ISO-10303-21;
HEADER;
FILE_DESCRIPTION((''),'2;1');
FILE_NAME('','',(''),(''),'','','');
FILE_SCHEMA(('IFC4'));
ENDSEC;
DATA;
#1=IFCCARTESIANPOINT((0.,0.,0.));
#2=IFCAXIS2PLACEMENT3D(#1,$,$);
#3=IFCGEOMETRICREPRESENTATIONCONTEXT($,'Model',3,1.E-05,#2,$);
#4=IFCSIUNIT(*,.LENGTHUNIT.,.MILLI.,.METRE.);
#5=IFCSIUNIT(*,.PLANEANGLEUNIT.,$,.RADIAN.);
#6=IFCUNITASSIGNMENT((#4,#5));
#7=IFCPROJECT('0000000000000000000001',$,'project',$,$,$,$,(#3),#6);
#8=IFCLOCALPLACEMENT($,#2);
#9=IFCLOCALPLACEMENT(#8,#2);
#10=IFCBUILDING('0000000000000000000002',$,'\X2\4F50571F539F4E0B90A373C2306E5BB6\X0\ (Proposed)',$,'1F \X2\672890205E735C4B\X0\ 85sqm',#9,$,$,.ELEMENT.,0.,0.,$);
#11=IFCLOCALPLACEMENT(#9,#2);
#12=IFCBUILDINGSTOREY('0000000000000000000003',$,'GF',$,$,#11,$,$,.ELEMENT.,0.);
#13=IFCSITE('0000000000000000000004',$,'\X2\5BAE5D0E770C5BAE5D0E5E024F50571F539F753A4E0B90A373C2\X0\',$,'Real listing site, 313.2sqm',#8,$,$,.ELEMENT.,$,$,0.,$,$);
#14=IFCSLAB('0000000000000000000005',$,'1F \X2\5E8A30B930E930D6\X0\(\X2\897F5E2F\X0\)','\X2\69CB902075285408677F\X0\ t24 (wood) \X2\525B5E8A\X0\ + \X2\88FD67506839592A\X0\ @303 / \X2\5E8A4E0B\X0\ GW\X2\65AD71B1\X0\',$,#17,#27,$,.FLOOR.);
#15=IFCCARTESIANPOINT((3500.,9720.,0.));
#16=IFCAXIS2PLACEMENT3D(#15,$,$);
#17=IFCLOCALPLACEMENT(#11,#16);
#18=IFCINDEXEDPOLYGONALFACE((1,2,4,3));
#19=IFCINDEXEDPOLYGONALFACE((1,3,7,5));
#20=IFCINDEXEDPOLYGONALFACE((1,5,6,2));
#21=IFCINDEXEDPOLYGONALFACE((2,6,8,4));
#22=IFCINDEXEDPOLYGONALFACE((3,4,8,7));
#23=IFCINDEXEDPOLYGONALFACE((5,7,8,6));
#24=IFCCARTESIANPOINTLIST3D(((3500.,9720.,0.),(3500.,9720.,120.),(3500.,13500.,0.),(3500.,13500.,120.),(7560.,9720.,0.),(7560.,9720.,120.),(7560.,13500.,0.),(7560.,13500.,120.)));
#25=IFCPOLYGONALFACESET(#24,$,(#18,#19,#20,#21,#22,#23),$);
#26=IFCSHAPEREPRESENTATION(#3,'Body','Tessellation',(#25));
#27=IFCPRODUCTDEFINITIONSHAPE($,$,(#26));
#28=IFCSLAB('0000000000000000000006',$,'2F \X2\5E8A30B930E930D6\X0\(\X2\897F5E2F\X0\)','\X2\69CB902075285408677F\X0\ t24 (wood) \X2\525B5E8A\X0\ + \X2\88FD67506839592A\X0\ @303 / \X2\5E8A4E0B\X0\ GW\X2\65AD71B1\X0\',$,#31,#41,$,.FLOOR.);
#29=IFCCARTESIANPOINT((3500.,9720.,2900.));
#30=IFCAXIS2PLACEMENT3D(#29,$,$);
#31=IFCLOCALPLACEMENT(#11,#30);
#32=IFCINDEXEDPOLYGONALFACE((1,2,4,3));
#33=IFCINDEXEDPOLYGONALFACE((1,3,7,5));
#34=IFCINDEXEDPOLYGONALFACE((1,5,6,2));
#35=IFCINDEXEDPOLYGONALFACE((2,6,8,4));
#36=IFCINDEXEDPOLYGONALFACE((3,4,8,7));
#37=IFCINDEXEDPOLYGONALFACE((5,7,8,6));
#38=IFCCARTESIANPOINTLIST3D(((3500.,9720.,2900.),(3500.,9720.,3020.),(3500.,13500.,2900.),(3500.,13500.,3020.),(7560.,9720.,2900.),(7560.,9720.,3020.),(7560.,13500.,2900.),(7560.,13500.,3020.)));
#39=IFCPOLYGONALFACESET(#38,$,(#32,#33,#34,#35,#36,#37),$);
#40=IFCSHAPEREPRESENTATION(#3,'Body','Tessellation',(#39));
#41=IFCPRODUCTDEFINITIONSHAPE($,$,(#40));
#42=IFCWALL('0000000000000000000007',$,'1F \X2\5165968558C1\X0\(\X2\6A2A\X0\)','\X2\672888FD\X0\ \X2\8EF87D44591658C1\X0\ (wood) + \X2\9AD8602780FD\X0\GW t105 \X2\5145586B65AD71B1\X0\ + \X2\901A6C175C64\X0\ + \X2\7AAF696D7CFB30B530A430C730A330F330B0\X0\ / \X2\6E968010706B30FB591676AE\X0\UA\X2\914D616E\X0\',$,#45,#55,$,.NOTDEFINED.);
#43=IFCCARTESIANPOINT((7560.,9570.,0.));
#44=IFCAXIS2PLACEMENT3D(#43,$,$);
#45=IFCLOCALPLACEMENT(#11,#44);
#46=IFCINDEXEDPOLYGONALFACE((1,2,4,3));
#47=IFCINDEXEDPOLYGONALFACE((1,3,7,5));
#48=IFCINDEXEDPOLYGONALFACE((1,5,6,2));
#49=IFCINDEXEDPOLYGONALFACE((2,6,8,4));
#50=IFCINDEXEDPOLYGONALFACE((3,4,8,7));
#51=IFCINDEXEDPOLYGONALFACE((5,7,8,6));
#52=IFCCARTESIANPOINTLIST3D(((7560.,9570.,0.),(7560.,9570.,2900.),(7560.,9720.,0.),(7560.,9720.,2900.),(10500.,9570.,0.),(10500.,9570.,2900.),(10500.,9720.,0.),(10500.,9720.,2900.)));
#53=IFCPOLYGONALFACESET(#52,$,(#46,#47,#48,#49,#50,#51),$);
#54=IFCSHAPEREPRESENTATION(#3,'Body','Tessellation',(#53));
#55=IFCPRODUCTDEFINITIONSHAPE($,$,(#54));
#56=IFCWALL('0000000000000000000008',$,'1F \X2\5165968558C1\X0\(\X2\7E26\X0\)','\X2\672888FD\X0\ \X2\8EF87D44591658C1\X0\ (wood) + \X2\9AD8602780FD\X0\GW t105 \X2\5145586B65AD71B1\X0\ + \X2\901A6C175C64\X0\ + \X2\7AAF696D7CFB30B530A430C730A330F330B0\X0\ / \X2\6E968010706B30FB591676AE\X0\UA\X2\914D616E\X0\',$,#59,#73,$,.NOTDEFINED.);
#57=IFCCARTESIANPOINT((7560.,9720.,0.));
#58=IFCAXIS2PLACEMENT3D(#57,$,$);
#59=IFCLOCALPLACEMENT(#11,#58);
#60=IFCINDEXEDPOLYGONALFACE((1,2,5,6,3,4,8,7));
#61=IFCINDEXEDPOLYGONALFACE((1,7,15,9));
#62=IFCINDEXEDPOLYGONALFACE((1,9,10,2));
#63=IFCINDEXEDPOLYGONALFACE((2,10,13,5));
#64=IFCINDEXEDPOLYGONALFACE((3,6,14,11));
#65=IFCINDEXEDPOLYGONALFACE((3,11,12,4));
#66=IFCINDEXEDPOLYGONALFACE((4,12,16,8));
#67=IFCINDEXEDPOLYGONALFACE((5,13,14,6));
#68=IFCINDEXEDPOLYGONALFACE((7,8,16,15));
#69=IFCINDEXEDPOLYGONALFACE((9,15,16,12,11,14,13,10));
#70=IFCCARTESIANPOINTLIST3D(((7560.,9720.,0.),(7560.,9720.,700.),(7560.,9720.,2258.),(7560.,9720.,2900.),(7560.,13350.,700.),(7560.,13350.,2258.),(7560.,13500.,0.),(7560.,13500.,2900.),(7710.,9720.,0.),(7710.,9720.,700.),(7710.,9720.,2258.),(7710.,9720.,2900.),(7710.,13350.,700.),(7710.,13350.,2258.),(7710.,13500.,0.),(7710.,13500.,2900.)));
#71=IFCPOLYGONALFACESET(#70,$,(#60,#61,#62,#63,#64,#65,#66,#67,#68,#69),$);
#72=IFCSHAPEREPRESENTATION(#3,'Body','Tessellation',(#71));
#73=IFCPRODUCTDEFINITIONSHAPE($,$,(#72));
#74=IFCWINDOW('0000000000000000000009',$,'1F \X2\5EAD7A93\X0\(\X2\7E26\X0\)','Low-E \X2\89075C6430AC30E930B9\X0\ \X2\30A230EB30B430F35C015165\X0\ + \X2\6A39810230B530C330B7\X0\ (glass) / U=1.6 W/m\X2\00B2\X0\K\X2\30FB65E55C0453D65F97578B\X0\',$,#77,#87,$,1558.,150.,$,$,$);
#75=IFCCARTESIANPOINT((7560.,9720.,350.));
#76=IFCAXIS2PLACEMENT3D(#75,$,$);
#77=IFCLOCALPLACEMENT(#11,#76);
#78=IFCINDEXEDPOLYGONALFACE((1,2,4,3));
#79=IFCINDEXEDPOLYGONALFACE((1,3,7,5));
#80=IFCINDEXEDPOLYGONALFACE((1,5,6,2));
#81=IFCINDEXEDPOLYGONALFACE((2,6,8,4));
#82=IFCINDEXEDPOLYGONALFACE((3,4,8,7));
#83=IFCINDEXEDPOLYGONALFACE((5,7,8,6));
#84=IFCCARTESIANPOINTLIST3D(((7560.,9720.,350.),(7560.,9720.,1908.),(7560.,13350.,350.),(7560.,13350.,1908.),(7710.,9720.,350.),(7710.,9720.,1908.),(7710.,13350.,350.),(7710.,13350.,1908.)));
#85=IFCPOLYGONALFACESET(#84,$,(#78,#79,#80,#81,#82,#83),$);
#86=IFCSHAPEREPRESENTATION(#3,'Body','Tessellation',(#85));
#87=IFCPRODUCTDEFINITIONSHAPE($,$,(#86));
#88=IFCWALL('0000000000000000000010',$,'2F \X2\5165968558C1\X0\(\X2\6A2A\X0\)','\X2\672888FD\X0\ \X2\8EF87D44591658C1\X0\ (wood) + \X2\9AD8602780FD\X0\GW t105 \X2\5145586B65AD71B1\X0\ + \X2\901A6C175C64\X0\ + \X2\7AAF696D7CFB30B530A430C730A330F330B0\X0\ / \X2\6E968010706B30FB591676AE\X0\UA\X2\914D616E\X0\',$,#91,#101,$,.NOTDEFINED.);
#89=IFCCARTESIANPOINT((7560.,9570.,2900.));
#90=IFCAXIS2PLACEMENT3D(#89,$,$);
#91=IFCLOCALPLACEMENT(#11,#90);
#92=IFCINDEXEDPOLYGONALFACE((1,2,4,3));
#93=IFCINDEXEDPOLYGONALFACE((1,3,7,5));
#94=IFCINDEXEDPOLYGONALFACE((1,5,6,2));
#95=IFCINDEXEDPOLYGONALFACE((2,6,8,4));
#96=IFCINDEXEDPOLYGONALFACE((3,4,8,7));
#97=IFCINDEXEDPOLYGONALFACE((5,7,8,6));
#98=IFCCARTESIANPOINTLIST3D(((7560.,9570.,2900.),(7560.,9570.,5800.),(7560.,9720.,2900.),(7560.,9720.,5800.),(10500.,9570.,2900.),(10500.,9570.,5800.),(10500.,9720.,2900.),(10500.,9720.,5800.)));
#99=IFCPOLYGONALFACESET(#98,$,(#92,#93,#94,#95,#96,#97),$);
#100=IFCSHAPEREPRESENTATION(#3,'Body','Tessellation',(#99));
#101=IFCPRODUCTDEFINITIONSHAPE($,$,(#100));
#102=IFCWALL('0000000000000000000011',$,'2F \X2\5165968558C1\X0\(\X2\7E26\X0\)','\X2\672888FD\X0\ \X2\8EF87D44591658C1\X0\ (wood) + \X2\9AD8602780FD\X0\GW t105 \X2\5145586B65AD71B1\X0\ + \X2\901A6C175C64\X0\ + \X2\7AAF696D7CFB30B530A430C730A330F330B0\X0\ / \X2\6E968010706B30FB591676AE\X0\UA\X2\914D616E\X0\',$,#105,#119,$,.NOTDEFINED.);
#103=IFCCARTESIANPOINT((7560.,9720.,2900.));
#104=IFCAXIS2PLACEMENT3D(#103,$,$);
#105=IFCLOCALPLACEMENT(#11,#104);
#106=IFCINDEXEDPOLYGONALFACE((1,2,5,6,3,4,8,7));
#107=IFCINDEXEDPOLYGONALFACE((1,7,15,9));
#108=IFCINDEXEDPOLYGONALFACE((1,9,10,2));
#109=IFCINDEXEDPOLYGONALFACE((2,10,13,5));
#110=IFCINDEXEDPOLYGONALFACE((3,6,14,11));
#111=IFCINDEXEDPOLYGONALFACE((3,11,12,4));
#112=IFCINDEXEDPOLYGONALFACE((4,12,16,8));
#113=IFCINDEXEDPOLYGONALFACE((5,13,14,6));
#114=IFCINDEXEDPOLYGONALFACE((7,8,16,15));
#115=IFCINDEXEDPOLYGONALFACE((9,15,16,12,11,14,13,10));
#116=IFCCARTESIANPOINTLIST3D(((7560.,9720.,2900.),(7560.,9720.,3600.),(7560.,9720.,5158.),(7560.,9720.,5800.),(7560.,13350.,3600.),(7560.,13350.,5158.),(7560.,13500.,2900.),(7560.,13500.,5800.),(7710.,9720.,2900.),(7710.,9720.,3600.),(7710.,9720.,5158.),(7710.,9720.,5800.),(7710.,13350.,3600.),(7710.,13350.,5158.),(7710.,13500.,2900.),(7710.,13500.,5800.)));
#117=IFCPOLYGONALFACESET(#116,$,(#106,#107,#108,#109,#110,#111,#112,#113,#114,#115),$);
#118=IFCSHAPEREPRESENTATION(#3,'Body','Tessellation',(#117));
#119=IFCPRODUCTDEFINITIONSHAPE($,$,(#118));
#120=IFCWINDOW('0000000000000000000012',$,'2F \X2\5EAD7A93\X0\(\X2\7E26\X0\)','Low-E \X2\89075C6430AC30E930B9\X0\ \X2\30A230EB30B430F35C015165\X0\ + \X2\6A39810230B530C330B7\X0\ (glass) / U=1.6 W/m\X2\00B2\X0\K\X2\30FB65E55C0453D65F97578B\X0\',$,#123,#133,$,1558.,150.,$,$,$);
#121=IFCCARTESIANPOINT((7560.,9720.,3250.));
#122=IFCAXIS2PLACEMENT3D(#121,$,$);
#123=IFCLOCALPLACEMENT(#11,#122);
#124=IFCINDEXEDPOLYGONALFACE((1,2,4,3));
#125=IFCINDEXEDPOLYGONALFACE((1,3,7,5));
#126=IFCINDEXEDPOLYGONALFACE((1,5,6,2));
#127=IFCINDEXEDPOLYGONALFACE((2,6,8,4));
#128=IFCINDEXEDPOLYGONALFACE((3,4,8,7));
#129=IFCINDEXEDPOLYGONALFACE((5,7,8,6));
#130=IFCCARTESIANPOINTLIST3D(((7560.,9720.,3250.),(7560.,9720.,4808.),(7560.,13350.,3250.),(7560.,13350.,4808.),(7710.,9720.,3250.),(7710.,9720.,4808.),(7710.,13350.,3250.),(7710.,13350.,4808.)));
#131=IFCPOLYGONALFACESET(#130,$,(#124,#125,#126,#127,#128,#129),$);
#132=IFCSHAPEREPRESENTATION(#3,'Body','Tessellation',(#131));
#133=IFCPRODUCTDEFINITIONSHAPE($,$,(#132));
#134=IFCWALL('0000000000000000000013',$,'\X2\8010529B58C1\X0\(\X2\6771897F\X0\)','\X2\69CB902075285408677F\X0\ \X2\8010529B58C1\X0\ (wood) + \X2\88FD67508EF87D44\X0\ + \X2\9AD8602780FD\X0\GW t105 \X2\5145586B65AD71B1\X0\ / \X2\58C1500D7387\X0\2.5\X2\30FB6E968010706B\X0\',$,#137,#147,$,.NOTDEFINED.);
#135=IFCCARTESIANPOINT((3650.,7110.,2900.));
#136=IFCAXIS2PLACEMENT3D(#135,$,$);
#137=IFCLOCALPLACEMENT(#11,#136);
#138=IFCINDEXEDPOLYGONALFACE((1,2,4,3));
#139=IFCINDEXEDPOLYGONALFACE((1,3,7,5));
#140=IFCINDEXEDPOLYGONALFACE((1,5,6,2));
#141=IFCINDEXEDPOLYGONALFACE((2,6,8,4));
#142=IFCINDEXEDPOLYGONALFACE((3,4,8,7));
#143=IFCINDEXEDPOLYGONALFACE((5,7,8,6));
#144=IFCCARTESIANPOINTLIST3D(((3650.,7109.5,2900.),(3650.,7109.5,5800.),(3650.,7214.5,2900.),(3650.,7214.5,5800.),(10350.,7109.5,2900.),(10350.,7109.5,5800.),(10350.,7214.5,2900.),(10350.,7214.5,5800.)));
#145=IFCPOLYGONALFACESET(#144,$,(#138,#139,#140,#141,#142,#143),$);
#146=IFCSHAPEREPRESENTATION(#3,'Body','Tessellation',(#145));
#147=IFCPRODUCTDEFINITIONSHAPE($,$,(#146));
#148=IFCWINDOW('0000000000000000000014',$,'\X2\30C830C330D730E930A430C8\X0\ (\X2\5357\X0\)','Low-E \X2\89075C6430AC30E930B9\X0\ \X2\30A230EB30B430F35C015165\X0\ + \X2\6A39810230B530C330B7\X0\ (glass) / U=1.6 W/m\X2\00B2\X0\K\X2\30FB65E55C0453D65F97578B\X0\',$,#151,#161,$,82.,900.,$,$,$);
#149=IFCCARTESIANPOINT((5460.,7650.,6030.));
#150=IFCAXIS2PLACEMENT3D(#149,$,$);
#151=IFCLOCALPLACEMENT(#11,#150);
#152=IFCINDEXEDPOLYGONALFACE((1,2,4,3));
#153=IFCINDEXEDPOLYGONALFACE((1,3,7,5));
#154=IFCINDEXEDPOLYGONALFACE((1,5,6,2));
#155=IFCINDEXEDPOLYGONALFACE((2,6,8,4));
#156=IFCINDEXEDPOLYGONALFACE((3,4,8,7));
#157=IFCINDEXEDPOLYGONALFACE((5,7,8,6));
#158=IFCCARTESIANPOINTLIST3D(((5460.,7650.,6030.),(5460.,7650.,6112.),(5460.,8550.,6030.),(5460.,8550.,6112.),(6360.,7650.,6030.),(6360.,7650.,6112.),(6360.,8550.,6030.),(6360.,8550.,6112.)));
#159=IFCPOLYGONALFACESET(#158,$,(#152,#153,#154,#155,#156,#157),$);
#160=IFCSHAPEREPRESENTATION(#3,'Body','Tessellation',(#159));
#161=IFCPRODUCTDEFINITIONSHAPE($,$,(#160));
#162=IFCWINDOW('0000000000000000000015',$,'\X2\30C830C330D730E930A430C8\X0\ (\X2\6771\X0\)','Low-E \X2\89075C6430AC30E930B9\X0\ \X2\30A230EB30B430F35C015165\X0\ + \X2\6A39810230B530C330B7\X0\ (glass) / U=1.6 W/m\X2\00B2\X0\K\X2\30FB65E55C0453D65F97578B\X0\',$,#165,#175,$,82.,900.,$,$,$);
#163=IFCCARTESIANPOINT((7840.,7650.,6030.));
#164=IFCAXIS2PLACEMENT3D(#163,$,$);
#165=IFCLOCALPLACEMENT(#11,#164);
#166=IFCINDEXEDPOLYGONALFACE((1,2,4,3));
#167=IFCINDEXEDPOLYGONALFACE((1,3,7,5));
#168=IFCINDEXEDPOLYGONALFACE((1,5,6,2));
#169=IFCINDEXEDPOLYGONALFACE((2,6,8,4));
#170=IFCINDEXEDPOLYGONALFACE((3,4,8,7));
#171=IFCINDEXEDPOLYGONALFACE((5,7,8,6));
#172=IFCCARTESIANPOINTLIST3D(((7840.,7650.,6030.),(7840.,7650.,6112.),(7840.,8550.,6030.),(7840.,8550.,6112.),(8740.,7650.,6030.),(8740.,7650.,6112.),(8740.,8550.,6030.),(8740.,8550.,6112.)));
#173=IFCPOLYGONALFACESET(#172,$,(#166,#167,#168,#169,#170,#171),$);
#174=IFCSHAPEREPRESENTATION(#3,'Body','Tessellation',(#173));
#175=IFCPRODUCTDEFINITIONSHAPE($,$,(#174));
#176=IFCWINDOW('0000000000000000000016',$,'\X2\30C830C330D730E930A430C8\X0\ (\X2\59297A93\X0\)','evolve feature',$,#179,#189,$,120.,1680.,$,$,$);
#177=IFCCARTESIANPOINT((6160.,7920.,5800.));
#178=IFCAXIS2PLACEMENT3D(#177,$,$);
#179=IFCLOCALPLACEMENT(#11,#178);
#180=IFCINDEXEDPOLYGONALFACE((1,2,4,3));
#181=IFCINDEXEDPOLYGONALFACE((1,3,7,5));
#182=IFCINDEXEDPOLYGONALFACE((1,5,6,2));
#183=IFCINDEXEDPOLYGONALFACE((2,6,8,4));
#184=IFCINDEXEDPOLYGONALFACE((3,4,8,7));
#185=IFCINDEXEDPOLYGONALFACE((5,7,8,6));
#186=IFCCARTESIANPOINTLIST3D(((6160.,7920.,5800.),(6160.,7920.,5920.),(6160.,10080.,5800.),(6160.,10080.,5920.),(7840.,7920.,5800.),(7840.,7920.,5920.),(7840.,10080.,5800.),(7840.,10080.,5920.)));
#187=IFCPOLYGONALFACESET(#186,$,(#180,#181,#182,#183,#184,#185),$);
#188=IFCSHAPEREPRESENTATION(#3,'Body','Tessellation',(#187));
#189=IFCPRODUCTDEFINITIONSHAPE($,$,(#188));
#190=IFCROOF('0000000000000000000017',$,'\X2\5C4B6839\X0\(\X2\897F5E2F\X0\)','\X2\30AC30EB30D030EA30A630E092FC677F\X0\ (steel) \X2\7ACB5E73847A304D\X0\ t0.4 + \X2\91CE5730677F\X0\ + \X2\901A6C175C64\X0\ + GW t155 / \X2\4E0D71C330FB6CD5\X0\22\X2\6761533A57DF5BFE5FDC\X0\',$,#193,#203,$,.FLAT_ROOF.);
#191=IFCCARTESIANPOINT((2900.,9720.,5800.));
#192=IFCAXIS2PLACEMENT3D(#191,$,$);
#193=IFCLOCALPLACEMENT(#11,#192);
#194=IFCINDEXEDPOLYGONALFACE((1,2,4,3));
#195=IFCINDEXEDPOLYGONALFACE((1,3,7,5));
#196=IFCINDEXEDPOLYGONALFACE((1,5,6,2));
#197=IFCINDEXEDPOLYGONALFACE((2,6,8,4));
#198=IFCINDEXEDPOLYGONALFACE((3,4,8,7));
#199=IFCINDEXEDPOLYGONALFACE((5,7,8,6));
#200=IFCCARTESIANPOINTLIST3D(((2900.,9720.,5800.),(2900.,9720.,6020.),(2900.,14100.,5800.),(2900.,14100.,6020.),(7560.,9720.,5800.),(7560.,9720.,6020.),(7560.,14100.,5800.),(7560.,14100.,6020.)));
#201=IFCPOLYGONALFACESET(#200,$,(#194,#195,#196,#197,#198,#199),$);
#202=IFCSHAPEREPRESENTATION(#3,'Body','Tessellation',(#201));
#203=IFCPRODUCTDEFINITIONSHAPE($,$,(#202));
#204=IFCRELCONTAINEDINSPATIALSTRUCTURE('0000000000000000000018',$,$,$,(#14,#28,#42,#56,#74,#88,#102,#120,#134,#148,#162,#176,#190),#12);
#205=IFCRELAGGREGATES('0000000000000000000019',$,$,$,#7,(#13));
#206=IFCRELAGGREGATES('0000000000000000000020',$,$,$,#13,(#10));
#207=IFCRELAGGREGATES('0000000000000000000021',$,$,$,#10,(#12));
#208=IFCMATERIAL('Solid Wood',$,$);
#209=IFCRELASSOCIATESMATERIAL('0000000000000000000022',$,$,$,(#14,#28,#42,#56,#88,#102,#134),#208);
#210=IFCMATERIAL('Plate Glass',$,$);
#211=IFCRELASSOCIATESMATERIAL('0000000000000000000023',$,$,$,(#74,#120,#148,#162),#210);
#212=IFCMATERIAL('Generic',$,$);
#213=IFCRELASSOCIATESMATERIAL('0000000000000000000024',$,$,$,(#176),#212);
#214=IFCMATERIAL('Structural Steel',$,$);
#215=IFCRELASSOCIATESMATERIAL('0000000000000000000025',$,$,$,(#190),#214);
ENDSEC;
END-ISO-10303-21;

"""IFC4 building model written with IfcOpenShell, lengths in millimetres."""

from ifc_helpers import new_model, si_unit, frame, frame_2d, origin, place, context, project, spatial, rectangle, extrude, material, element, fill, save


model = new_model("IFC4")

# Units and contexts
model_context = context("Model", 3, precision=1e-05, world=origin())
ifc_project = project(units=[si_unit("LENGTHUNIT", "METRE", prefix="MILLI"), si_unit("PLANEANGLEUNIT", "RADIAN")], contexts=[model_context])

# Site, building, storey
site_placement = place(None, origin())
site = spatial("IfcSite", under=ifc_project, at=site_placement, Name="宮崎県宮崎市佐土原町下那珂", ObjectType="Real listing site, 313.2sqm", CompositionType="ELEMENT", RefElevation=0.0)
building_placement = place(site_placement, origin())
building = spatial("IfcBuilding", under=site, at=building_placement, Name="佐土原下那珂の家 (Proposed)", ObjectType="1F 木造平屋 85sqm", CompositionType="ELEMENT", ElevationOfRefHeight=0.0, ElevationOfTerrain=0.0)
storey_placement = place(building_placement, origin())
storey = spatial("IfcBuildingStorey", under=building, at=storey_placement, Name="GF", CompositionType="ELEMENT", Elevation=0.0)

# Slabs
ifc_material_1 = material(Name="Solid Wood")
slab_1_placement = place(storey_placement, frame((3500.0, 9720.0, 0.0)))
element("IfcSlab", 1, at=slab_1_placement, inside=storey, material=ifc_material_1, Name="1F 床スラブ(西帯)", Description="構造用合板 t24 (wood) 剛床 + 製材根太 @303 / 床下 GW断熱", PredefinedType="FLOOR", context=model_context, shape_type="SweptSolid", body=[
    extrude(rectangle(XDim=4060.0, YDim=3780.0, at=frame_2d((2030.0, 1890.0))), frame((3500.0, 9720.0, 0.0)), (0.0, 0.0, 1.0), 120.0),
])
slab_2_placement = place(storey_placement, frame((3500.0, 9720.0, 2900.0)))
element("IfcSlab", 2, at=slab_2_placement, inside=storey, material=ifc_material_1, Name="2F 床スラブ(西帯)", Description="構造用合板 t24 (wood) 剛床 + 製材根太 @303 / 床下 GW断熱", PredefinedType="FLOOR", context=model_context, shape_type="SweptSolid", body=[
    extrude(rectangle(XDim=4060.0, YDim=3780.0, at=frame_2d((2030.0, 1890.0))), frame((3500.0, 9720.0, 2900.0)), (0.0, 0.0, 1.0), 120.0),
])

# Wall
wall_1_placement = place(storey_placement, frame((7560.0, 9570.0, 0.0)))
element("IfcWall", 3, at=wall_1_placement, inside=storey, material=ifc_material_1, Name="1F 入隅壁(横)", Description="木製 軸組外壁 (wood) + 高性能GW t105 充填断熱 + 通気層 + 窯業系サイディング / 準耐火・外皮UA配慮", PredefinedType="NOTDEFINED", context=model_context, shape_type="SweptSolid", body=[
    extrude(rectangle(XDim=2940.0, YDim=150.0, at=frame_2d((1470.0, 75.0))), frame((7560.0, 9570.0, 0.0)), (0.0, 0.0, 1.0), 2900.0),
])

# Wall, opening, window
wall_2_placement = place(storey_placement, frame((7560.0, 9720.0, 0.0)))
wall_2 = element("IfcWall", 4, at=wall_2_placement, inside=storey, material=ifc_material_1, Name="1F 入隅壁(縦)", Description="木製 軸組外壁 (wood) + 高性能GW t105 充填断熱 + 通気層 + 窯業系サイディング / 準耐火・外皮UA配慮", PredefinedType="NOTDEFINED", context=model_context, shape_type="SweptSolid", body=[
    extrude(rectangle(XDim=150.0, YDim=3780.0, at=frame_2d((75.0, 1890.0))), frame((7560.0, 9720.0, 0.0)), (0.0, 0.0, 1.0), 2900.0),
])
opening_1_placement = place(storey_placement, frame((7560.0, 9720.0, 350.0)))
opening_1 = element("IfcOpeningElement", 5, at=opening_1_placement, cuts=wall_2, PredefinedType="NOTDEFINED", context=model_context, shape_type="SweptSolid", body=[
    extrude(rectangle(XDim=150.0, YDim=3630.0, at=frame_2d((75.0, 1815.0))), frame((7560.0, 9720.0, 350.0)), (0.0, 0.0, 1.0), 1558.0),
])
ifc_material_2 = material(Name="Plate Glass")
window_1_placement = place(storey_placement, frame((7560.0, 9720.0, 350.0)))
window_1 = element("IfcWindow", 6, at=window_1_placement, inside=storey, material=ifc_material_2, Name="1F 庭窓(縦)", Description="Low-E 複層ガラス アルゴン封入 + 樹脂サッシ (glass) / U=1.6 W/m²K・日射取得型", OverallHeight=1558.0, OverallWidth=150.0, context=model_context, shape_type="SweptSolid", body=[
    extrude(rectangle(XDim=150.0, YDim=3630.0, at=frame_2d((75.0, 1815.0))), frame((7560.0, 9720.0, 350.0)), (0.0, 0.0, 1.0), 1558.0),
])
fill(opening_1, window_1)

# Wall
wall_3_placement = place(storey_placement, frame((7560.0, 9570.0, 2900.0)))
element("IfcWall", 7, at=wall_3_placement, inside=storey, material=ifc_material_1, Name="2F 入隅壁(横)", Description="木製 軸組外壁 (wood) + 高性能GW t105 充填断熱 + 通気層 + 窯業系サイディング / 準耐火・外皮UA配慮", PredefinedType="NOTDEFINED", context=model_context, shape_type="SweptSolid", body=[
    extrude(rectangle(XDim=2940.0, YDim=150.0, at=frame_2d((1470.0, 75.0))), frame((7560.0, 9570.0, 2900.0)), (0.0, 0.0, 1.0), 2900.0),
])

# Wall, opening, window
wall_4_placement = place(storey_placement, frame((7560.0, 9720.0, 2900.0)))
wall_4 = element("IfcWall", 8, at=wall_4_placement, inside=storey, material=ifc_material_1, Name="2F 入隅壁(縦)", Description="木製 軸組外壁 (wood) + 高性能GW t105 充填断熱 + 通気層 + 窯業系サイディング / 準耐火・外皮UA配慮", PredefinedType="NOTDEFINED", context=model_context, shape_type="SweptSolid", body=[
    extrude(rectangle(XDim=150.0, YDim=3780.0, at=frame_2d((75.0, 1890.0))), frame((7560.0, 9720.0, 2900.0)), (0.0, 0.0, 1.0), 2900.0),
])
opening_2_placement = place(storey_placement, frame((7560.0, 9720.0, 3250.0)))
opening_2 = element("IfcOpeningElement", 9, at=opening_2_placement, cuts=wall_4, PredefinedType="NOTDEFINED", context=model_context, shape_type="SweptSolid", body=[
    extrude(rectangle(XDim=150.0, YDim=3630.0, at=frame_2d((75.0, 1815.0))), frame((7560.0, 9720.0, 3250.0)), (0.0, 0.0, 1.0), 1558.0),
])
window_2_placement = place(storey_placement, frame((7560.0, 9720.0, 3250.0)))
window_2 = element("IfcWindow", 10, at=window_2_placement, inside=storey, material=ifc_material_2, Name="2F 庭窓(縦)", Description="Low-E 複層ガラス アルゴン封入 + 樹脂サッシ (glass) / U=1.6 W/m²K・日射取得型", OverallHeight=1558.0, OverallWidth=150.0, context=model_context, shape_type="SweptSolid", body=[
    extrude(rectangle(XDim=150.0, YDim=3630.0, at=frame_2d((75.0, 1815.0))), frame((7560.0, 9720.0, 3250.0)), (0.0, 0.0, 1.0), 1558.0),
])
fill(opening_2, window_2)

# Wall
wall_5_placement = place(storey_placement, frame((3650.0, 7110.0, 2900.0)))
element("IfcWall", 11, at=wall_5_placement, inside=storey, material=ifc_material_1, Name="耐力壁(東西)", Description="構造用合板 耐力壁 (wood) + 製材軸組 + 高性能GW t105 充填断熱 / 壁倍率2.5・準耐火", PredefinedType="NOTDEFINED", context=model_context, shape_type="SweptSolid", body=[
    extrude(rectangle(XDim=6700.0, YDim=105.0, at=frame_2d((3350.0, 52.0))), frame((3650.0, 7110.0, 2900.0)), (0.0, 0.0, 1.0), 2900.0),
])

# Windows
window_3_placement = place(storey_placement, frame((5460.0, 7650.0, 6030.0)))
element("IfcWindow", 12, at=window_3_placement, inside=storey, material=ifc_material_2, Name="トップライト (南)", Description="Low-E 複層ガラス アルゴン封入 + 樹脂サッシ (glass) / U=1.6 W/m²K・日射取得型", OverallHeight=82.0, OverallWidth=900.0, context=model_context, shape_type="SweptSolid", body=[
    extrude(rectangle(XDim=900.0, YDim=900.0, at=frame_2d((450.0, 450.0))), frame((5460.0, 7650.0, 6030.0)), (0.0, 0.0, 1.0), 82.0),
])
window_4_placement = place(storey_placement, frame((7840.0, 7650.0, 6030.0)))
element("IfcWindow", 13, at=window_4_placement, inside=storey, material=ifc_material_2, Name="トップライト (東)", Description="Low-E 複層ガラス アルゴン封入 + 樹脂サッシ (glass) / U=1.6 W/m²K・日射取得型", OverallHeight=82.0, OverallWidth=900.0, context=model_context, shape_type="SweptSolid", body=[
    extrude(rectangle(XDim=900.0, YDim=900.0, at=frame_2d((450.0, 450.0))), frame((7840.0, 7650.0, 6030.0)), (0.0, 0.0, 1.0), 82.0),
])
ifc_material_3 = material(Name="Generic")
window_5_placement = place(storey_placement, frame((6160.0, 7920.0, 5800.0)))
element("IfcWindow", 14, at=window_5_placement, inside=storey, material=ifc_material_3, Name="トップライト (天窓)", Description="evolve feature", OverallHeight=120.0, OverallWidth=1680.0, context=model_context, shape_type="SweptSolid", body=[
    extrude(rectangle(XDim=1680.0, YDim=2160.0, at=frame_2d((840.0, 1080.0))), frame((6160.0, 7920.0, 5800.0)), (0.0, 0.0, 1.0), 120.0),
])

# Roof
ifc_material_4 = material(Name="Structural Steel")
for number, where, name in (
    (15, (2900.0, 9720.0, 5800.0), "屋根(西帯)"),
):
    element("IfcRoof", number, at=place(storey_placement, frame(where)), inside=storey, material=ifc_material_4, Name=name, Description="ガルバリウム鋼板 (steel) 立平葺き t0.4 + 野地板 + 通気層 + GW t155 / 不燃・法22条区域対応", PredefinedType="FLAT_ROOF", context=model_context, shape_type="SweptSolid", body=[
        extrude(rectangle(XDim=4660.0, YDim=4380.0, at=frame_2d((2330.0, 2190.0))), frame((2900.0, 9720.0, 5800.0)), (0.0, 0.0, 1.0), 220.0),
    ])

save(model, "model.ifc")
